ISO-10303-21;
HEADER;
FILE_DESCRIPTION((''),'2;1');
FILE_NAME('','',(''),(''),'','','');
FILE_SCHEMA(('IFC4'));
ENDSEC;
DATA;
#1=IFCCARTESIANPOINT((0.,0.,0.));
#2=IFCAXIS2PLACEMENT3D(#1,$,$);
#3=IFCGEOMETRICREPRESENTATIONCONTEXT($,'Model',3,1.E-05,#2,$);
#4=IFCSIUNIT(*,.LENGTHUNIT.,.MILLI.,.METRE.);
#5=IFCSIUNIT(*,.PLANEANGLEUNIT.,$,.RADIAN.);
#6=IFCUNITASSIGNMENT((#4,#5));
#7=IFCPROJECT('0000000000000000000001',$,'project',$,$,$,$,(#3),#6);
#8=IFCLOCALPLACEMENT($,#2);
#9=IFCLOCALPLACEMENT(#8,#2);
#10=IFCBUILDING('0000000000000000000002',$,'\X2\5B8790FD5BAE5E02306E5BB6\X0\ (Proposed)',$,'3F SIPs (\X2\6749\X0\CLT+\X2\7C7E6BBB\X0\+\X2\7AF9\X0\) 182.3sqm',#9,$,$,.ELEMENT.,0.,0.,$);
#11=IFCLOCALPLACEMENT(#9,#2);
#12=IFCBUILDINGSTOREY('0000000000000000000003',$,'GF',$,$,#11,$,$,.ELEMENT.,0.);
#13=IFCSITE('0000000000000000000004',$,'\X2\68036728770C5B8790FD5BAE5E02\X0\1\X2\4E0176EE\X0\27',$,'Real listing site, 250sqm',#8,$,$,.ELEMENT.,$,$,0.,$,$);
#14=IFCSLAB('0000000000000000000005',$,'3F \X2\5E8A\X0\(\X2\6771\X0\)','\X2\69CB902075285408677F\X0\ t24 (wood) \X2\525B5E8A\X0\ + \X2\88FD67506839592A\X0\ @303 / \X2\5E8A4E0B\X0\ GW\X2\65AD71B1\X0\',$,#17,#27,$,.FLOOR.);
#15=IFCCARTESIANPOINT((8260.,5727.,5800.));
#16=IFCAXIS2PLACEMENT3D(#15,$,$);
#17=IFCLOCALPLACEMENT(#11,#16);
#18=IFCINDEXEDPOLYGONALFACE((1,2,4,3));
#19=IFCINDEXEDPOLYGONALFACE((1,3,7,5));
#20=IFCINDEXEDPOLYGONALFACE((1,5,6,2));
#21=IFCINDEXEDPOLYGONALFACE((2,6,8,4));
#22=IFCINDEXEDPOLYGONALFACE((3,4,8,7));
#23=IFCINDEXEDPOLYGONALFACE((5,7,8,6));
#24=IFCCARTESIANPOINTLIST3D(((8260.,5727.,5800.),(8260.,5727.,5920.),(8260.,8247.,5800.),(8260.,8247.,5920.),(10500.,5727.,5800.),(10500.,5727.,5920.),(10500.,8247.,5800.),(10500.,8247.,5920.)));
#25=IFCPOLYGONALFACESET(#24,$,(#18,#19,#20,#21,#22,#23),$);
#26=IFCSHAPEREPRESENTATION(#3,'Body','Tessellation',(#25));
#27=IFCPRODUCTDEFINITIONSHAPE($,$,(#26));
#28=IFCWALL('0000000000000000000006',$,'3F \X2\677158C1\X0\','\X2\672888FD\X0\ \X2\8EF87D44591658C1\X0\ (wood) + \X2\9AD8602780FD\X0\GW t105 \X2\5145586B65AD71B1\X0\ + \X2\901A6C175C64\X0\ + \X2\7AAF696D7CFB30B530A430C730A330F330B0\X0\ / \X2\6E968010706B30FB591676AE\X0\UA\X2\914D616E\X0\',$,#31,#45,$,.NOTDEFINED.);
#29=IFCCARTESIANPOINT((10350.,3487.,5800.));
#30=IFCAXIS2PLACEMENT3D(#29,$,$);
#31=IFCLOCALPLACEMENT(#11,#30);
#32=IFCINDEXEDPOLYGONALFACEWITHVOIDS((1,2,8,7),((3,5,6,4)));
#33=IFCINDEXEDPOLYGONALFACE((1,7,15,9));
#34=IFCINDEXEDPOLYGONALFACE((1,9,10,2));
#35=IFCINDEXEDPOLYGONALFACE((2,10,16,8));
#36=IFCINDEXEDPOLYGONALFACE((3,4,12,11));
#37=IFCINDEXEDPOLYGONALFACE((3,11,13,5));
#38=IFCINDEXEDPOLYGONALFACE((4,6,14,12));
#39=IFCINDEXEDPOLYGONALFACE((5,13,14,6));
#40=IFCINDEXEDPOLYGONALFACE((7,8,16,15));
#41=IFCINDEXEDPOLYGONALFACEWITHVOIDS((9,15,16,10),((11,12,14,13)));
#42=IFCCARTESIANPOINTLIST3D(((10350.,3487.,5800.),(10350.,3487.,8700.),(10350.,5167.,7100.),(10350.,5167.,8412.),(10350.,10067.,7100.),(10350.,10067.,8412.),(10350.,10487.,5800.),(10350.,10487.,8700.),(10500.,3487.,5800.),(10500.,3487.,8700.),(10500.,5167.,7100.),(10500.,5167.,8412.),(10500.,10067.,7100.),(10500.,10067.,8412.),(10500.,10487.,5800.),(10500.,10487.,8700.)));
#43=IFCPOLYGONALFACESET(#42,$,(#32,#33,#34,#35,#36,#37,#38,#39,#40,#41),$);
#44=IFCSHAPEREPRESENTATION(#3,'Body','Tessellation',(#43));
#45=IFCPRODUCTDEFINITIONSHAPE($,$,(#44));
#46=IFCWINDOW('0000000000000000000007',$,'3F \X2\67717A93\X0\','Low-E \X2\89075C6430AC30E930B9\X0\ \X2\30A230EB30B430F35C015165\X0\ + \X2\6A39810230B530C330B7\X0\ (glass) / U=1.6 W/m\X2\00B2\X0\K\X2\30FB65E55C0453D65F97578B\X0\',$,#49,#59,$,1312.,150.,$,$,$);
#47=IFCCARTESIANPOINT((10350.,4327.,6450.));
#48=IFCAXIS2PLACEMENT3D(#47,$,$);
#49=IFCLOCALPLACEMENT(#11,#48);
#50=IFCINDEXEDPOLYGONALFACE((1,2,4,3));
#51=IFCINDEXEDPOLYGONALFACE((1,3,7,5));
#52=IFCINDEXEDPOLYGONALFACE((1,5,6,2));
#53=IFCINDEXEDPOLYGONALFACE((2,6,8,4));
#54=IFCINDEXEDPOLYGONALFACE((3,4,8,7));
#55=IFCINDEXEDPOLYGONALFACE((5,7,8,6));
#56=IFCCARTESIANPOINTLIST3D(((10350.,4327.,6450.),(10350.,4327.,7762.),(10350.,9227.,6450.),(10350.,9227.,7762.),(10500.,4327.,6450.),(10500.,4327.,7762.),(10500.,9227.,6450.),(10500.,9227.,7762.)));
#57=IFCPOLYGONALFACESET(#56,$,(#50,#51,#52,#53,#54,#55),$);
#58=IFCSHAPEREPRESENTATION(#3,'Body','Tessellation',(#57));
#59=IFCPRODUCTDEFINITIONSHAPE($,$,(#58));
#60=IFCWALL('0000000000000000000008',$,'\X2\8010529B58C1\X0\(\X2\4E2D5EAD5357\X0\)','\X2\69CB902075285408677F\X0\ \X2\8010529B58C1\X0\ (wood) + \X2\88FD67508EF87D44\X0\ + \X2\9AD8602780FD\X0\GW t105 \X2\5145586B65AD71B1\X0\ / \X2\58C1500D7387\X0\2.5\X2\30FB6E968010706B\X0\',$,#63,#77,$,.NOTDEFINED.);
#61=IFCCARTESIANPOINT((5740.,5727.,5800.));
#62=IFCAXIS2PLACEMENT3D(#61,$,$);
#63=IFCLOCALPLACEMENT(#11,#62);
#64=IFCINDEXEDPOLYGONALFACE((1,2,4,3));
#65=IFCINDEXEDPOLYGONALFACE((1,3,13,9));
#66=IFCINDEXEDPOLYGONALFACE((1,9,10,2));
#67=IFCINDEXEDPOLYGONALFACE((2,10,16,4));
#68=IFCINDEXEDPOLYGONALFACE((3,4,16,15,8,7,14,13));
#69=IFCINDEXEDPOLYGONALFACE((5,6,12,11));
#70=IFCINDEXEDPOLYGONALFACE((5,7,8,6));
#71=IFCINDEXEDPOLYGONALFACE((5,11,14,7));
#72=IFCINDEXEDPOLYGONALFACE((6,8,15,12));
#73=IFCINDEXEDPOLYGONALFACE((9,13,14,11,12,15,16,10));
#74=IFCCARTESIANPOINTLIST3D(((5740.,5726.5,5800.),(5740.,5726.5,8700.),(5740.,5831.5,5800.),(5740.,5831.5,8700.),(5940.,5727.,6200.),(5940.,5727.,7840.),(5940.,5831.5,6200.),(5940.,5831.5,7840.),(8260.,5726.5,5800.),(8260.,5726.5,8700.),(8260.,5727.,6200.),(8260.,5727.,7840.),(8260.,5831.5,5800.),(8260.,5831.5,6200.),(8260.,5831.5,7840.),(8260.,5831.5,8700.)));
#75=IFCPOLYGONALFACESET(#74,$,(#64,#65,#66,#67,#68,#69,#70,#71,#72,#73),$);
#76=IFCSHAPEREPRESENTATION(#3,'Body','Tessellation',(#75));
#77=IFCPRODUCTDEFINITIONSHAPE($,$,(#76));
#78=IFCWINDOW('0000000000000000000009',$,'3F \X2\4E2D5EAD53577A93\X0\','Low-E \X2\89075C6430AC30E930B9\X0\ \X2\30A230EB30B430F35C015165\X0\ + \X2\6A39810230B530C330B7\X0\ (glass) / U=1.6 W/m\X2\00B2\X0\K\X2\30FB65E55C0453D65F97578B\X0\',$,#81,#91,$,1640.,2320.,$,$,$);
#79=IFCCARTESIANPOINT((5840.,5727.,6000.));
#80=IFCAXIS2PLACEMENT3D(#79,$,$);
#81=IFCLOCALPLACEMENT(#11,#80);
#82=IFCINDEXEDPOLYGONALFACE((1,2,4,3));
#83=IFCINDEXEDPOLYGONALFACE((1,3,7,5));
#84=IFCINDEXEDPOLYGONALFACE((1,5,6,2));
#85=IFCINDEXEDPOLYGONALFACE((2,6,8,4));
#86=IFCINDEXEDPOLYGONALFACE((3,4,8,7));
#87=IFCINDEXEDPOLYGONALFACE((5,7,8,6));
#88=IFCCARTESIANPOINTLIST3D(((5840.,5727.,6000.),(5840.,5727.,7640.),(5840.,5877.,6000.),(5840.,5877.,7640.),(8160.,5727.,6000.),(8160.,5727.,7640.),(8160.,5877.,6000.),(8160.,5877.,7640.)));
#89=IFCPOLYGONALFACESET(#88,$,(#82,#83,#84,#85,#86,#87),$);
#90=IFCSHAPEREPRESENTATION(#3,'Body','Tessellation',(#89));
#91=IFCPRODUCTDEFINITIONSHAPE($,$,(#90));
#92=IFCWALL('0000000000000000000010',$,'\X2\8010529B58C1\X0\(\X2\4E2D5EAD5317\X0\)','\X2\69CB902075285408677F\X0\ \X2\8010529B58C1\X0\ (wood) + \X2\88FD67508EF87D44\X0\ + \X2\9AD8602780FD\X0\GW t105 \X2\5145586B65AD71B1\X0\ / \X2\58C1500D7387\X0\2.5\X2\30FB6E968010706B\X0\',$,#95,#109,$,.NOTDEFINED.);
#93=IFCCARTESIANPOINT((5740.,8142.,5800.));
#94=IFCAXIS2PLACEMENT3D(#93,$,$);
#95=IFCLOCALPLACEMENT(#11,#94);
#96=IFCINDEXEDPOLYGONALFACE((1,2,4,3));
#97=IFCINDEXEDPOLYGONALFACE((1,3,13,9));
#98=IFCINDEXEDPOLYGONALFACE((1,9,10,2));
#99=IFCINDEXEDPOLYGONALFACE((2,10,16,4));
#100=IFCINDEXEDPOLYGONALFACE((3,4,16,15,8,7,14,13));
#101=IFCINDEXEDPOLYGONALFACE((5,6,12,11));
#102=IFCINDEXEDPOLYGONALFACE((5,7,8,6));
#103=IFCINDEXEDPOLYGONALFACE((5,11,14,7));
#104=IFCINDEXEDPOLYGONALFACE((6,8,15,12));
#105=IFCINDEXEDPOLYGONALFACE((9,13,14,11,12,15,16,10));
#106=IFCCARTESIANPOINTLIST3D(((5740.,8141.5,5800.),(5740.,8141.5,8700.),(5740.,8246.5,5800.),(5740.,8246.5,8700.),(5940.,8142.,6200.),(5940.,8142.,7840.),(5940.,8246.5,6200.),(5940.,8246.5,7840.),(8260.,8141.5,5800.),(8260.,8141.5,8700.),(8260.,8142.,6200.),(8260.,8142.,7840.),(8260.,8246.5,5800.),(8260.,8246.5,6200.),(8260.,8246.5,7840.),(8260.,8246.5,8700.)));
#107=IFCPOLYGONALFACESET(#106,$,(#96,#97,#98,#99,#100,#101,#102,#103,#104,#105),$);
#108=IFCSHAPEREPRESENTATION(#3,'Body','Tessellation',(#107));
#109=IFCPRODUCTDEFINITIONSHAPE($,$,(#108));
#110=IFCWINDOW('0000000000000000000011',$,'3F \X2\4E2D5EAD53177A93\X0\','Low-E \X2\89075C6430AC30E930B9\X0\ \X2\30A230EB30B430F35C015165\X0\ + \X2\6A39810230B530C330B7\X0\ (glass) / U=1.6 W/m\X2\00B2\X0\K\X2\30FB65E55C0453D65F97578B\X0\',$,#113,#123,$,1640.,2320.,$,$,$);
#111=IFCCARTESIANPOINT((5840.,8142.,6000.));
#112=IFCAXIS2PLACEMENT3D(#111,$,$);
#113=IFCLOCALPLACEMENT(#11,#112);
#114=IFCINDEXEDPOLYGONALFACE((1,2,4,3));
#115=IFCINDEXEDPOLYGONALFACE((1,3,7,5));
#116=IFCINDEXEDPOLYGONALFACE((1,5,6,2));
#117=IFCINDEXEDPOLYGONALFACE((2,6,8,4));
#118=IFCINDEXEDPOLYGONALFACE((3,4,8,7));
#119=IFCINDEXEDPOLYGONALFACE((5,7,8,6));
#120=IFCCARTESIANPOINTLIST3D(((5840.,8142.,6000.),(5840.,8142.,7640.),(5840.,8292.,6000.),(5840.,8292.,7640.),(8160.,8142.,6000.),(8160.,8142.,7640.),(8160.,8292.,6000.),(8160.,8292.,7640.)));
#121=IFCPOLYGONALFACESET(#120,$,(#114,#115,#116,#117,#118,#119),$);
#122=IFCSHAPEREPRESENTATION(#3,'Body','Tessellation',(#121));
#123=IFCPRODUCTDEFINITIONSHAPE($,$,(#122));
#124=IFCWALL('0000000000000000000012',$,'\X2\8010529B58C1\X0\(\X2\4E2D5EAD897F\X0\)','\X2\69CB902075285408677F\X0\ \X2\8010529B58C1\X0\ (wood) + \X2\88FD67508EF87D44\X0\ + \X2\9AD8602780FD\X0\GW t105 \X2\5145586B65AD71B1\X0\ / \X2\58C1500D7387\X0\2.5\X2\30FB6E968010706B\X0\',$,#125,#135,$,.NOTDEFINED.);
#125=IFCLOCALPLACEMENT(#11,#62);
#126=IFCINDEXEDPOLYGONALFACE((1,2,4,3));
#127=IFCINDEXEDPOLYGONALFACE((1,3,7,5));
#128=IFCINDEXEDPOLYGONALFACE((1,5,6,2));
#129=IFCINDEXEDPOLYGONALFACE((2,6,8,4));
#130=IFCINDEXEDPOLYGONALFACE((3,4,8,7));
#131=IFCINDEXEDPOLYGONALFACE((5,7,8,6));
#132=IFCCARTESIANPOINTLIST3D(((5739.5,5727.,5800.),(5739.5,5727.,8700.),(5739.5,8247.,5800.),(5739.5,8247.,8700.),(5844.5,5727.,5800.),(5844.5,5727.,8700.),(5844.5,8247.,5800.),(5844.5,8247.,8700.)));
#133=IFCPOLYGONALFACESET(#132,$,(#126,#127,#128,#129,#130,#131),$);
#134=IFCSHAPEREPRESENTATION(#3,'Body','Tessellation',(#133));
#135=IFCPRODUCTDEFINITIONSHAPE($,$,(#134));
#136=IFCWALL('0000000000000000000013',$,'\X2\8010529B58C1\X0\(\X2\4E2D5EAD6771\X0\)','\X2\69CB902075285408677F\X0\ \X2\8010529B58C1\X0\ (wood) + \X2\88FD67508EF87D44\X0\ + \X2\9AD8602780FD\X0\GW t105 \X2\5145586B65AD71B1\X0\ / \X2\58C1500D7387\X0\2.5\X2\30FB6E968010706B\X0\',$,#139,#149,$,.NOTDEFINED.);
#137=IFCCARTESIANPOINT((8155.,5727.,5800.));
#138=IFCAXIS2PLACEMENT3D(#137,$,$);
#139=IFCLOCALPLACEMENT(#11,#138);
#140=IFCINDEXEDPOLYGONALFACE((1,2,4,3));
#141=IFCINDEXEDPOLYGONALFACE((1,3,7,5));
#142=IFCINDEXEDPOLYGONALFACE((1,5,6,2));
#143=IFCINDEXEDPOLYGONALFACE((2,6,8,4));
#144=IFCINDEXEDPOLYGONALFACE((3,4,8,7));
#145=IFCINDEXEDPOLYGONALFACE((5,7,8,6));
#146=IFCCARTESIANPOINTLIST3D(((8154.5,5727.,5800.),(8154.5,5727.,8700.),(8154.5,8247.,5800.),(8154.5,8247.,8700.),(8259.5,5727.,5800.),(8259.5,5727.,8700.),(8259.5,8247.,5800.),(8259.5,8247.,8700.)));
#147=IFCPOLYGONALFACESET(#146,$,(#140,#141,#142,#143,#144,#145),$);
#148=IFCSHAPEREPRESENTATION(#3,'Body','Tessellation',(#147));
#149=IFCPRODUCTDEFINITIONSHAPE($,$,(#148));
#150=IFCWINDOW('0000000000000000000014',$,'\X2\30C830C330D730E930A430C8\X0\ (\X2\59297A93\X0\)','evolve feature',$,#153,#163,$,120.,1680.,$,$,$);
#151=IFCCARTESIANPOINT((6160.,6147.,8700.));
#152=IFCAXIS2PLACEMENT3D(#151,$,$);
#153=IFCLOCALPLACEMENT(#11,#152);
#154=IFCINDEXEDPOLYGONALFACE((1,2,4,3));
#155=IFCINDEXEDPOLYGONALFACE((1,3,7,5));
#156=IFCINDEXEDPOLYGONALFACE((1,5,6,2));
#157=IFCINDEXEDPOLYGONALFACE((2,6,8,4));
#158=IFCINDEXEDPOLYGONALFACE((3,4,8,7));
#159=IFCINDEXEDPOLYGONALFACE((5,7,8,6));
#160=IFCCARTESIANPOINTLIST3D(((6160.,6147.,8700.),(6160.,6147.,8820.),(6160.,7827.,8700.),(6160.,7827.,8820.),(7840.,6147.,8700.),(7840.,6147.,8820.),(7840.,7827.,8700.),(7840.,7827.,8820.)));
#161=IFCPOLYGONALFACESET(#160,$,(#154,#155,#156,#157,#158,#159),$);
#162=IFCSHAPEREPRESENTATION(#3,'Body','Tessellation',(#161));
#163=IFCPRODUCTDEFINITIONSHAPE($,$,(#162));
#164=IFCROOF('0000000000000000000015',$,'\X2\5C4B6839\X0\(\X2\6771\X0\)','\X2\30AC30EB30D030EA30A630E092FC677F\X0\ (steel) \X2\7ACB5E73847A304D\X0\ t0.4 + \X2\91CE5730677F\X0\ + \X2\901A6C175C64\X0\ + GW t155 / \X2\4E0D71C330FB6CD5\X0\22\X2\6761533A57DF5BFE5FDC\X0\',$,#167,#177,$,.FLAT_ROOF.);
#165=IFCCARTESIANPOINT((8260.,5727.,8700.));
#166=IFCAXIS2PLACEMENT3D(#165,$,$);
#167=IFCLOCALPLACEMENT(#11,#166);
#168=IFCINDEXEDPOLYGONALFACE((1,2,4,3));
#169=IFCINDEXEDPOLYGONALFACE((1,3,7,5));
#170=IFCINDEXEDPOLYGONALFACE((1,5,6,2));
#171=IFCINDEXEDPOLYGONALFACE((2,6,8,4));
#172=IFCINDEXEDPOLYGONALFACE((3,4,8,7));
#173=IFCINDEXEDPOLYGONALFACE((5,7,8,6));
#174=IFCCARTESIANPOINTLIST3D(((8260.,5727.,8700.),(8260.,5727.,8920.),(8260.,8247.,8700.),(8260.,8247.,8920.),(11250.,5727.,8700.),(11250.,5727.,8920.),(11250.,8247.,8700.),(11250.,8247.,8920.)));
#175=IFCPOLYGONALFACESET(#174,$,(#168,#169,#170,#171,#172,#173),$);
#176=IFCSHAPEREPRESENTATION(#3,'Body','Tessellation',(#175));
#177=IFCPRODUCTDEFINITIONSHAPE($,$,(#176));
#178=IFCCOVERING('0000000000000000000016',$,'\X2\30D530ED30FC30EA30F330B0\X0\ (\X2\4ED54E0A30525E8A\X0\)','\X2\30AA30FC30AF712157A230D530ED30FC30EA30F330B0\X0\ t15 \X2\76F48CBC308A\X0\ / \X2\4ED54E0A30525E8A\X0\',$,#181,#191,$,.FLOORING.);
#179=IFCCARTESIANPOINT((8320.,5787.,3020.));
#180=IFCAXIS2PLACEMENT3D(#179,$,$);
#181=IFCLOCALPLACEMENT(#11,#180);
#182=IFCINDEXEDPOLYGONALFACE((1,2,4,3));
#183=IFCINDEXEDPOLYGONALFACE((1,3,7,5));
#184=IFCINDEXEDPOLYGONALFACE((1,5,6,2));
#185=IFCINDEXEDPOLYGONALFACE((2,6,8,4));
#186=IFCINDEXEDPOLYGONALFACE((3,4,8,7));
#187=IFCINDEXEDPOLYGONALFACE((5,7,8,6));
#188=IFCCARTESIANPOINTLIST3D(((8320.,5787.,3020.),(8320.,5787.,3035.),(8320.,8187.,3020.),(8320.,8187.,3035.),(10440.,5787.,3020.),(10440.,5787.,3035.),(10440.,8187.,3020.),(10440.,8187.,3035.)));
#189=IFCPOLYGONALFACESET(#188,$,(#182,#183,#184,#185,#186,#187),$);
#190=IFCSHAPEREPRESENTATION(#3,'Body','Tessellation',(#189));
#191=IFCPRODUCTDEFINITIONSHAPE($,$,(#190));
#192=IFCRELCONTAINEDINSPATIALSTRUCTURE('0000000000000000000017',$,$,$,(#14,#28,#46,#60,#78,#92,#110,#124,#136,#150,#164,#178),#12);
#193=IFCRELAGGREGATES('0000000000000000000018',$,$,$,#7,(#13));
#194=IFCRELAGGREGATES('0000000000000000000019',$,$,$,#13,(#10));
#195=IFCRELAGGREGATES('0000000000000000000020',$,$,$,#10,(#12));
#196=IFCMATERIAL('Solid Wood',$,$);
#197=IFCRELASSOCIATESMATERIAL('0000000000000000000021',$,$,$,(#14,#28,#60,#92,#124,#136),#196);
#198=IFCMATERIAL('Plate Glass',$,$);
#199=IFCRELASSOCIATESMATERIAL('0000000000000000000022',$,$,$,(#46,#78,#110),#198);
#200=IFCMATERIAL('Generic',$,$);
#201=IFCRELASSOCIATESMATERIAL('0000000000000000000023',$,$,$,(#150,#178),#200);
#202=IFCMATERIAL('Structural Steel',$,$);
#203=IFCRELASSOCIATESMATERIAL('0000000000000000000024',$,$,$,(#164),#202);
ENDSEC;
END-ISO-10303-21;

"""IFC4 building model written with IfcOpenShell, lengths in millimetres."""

from ifc_helpers import new_model, si_unit, frame, frame_2d, origin, place, context, project, spatial, rectangle, extrude, material, element, fill, save


model = new_model("IFC4")

# Units and contexts
model_context = context("Model", 3, precision=1e-05, world=origin())
ifc_project = project(units=[si_unit("LENGTHUNIT", "METRE", prefix="MILLI"), si_unit("PLANEANGLEUNIT", "RADIAN")], contexts=[model_context])

# Site, building, storey
site_placement = place(None, origin())
site = spatial("IfcSite", under=ifc_project, at=site_placement, Name="栃木県宇都宮市1丁目27", ObjectType="Real listing site, 250sqm", CompositionType="ELEMENT", RefElevation=0.0)
building_placement = place(site_placement, origin())
building = spatial("IfcBuilding", under=site, at=building_placement, Name="宇都宮市の家 (Proposed)", ObjectType="3F SIPs (杉CLT+籾殻+竹) 182.3sqm", CompositionType="ELEMENT", ElevationOfRefHeight=0.0, ElevationOfTerrain=0.0)
storey_placement = place(building_placement, origin())
storey = spatial("IfcBuildingStorey", under=building, at=storey_placement, Name="GF", CompositionType="ELEMENT", Elevation=0.0)

# Slab
ifc_material_1 = material(Name="Solid Wood")
slab_placement = place(storey_placement, frame((8260.0, 5727.0, 5800.0)))
element("IfcSlab", 1, at=slab_placement, inside=storey, material=ifc_material_1, Name="3F 床(東)", Description="構造用合板 t24 (wood) 剛床 + 製材根太 @303 / 床下 GW断熱", PredefinedType="FLOOR", context=model_context, shape_type="SweptSolid", body=[
    extrude(rectangle(XDim=2240.0, YDim=2520.0, at=frame_2d((1120.0, 1260.0))), frame((8260.0, 5727.0, 5800.0)), (0.0, 0.0, 1.0), 120.0),
])

# Walls, openings, windows
wall_1_placement = place(storey_placement, frame((10350.0, 3487.0, 5800.0)))
wall_1 = element("IfcWall", 2, at=wall_1_placement, inside=storey, material=ifc_material_1, Name="3F 東壁", Description="木製 軸組外壁 (wood) + 高性能GW t105 充填断熱 + 通気層 + 窯業系サイディング / 準耐火・外皮UA配慮", PredefinedType="NOTDEFINED", context=model_context, shape_type="SweptSolid", body=[
    extrude(rectangle(XDim=150.0, YDim=7000.0, at=frame_2d((75.0, 3500.0))), frame((10350.0, 3487.0, 5800.0)), (0.0, 0.0, 1.0), 2900.0),
])
opening_1_placement = place(storey_placement, frame((10350.0, 4327.0, 6450.0)))
opening_1 = element("IfcOpeningElement", 3, at=opening_1_placement, cuts=wall_1, PredefinedType="NOTDEFINED", context=model_context, shape_type="SweptSolid", body=[
    extrude(rectangle(XDim=150.0, YDim=4900.0, at=frame_2d((75.0, 2450.0))), frame((10350.0, 4327.0, 6450.0)), (0.0, 0.0, 1.0), 1312.0),
])
ifc_material_2 = material(Name="Plate Glass")
window_1_placement = place(storey_placement, frame((10350.0, 4327.0, 6450.0)))
window_1 = element("IfcWindow", 4, at=window_1_placement, inside=storey, material=ifc_material_2, Name="3F 東窓", Description="Low-E 複層ガラス アルゴン封入 + 樹脂サッシ (glass) / U=1.6 W/m²K・日射取得型", OverallHeight=1312.0, OverallWidth=150.0, context=model_context, shape_type="SweptSolid", body=[
    extrude(rectangle(XDim=150.0, YDim=4900.0, at=frame_2d((75.0, 2450.0))), frame((10350.0, 4327.0, 6450.0)), (0.0, 0.0, 1.0), 1312.0),
])
fill(opening_1, window_1)
wall_2_placement = place(storey_placement, frame((5740.0, 5727.0, 5800.0)))
wall_2 = element("IfcWall", 5, at=wall_2_placement, inside=storey, material=ifc_material_1, Name="耐力壁(中庭南)", Description="構造用合板 耐力壁 (wood) + 製材軸組 + 高性能GW t105 充填断熱 / 壁倍率2.5・準耐火", PredefinedType="NOTDEFINED", context=model_context, shape_type="SweptSolid", body=[
    extrude(rectangle(XDim=2520.0, YDim=105.0, at=frame_2d((1260.0, 52.0))), frame((5740.0, 5727.0, 5800.0)), (0.0, 0.0, 1.0), 2900.0),
])
opening_2_placement = place(storey_placement, frame((5840.0, 5727.0, 6000.0)))
opening_2 = element("IfcOpeningElement", 6, at=opening_2_placement, cuts=wall_2, PredefinedType="NOTDEFINED", context=model_context, shape_type="SweptSolid", body=[
    extrude(rectangle(XDim=2320.0, YDim=150.0, at=frame_2d((1160.0, 75.0))), frame((5840.0, 5727.0, 6000.0)), (0.0, 0.0, 1.0), 1640.0),
])
window_2_placement = place(storey_placement, frame((5840.0, 5727.0, 6000.0)))
window_2 = element("IfcWindow", 7, at=window_2_placement, inside=storey, material=ifc_material_2, Name="3F 中庭南窓", Description="Low-E 複層ガラス アルゴン封入 + 樹脂サッシ (glass) / U=1.6 W/m²K・日射取得型", OverallHeight=1640.0, OverallWidth=2320.0, context=model_context, shape_type="SweptSolid", body=[
    extrude(rectangle(XDim=2320.0, YDim=150.0, at=frame_2d((1160.0, 75.0))), frame((5840.0, 5727.0, 6000.0)), (0.0, 0.0, 1.0), 1640.0),
])
fill(opening_2, window_2)
wall_3_placement = place(storey_placement, frame((5740.0, 8142.0, 5800.0)))
wall_3 = element("IfcWall", 8, at=wall_3_placement, inside=storey, material=ifc_material_1, Name="耐力壁(中庭北)", Description="構造用合板 耐力壁 (wood) + 製材軸組 + 高性能GW t105 充填断熱 / 壁倍率2.5・準耐火", PredefinedType="NOTDEFINED", context=model_context, shape_type="SweptSolid", body=[
    extrude(rectangle(XDim=2520.0, YDim=105.0, at=frame_2d((1260.0, 52.0))), frame((5740.0, 8142.0, 5800.0)), (0.0, 0.0, 1.0), 2900.0),
])
opening_3_placement = place(storey_placement, frame((5840.0, 8142.0, 6000.0)))
opening_3 = element("IfcOpeningElement", 9, at=opening_3_placement, cuts=wall_3, PredefinedType="NOTDEFINED", context=model_context, shape_type="SweptSolid", body=[
    extrude(rectangle(XDim=2320.0, YDim=150.0, at=frame_2d((1160.0, 75.0))), frame((5840.0, 8142.0, 6000.0)), (0.0, 0.0, 1.0), 1640.0),
])
window_3_placement = place(storey_placement, frame((5840.0, 8142.0, 6000.0)))
window_3 = element("IfcWindow", 10, at=window_3_placement, inside=storey, material=ifc_material_2, Name="3F 中庭北窓", Description="Low-E 複層ガラス アルゴン封入 + 樹脂サッシ (glass) / U=1.6 W/m²K・日射取得型", OverallHeight=1640.0, OverallWidth=2320.0, context=model_context, shape_type="SweptSolid", body=[
    extrude(rectangle(XDim=2320.0, YDim=150.0, at=frame_2d((1160.0, 75.0))), frame((5840.0, 8142.0, 6000.0)), (0.0, 0.0, 1.0), 1640.0),
])
fill(opening_3, window_3)

# Walls
wall_4_placement = place(storey_placement, frame((5740.0, 5727.0, 5800.0)))
element("IfcWall", 11, at=wall_4_placement, inside=storey, material=ifc_material_1, Name="耐力壁(中庭西)", Description="構造用合板 耐力壁 (wood) + 製材軸組 + 高性能GW t105 充填断熱 / 壁倍率2.5・準耐火", PredefinedType="NOTDEFINED", context=model_context, shape_type="SweptSolid", body=[
    extrude(rectangle(XDim=105.0, YDim=2520.0, at=frame_2d((52.0, 1260.0))), frame((5740.0, 5727.0, 5800.0)), (0.0, 0.0, 1.0), 2900.0),
])
wall_5_placement = place(storey_placement, frame((8155.0, 5727.0, 5800.0)))
element("IfcWall", 12, at=wall_5_placement, inside=storey, material=ifc_material_1, Name="耐力壁(中庭東)", Description="構造用合板 耐力壁 (wood) + 製材軸組 + 高性能GW t105 充填断熱 / 壁倍率2.5・準耐火", PredefinedType="NOTDEFINED", context=model_context, shape_type="SweptSolid", body=[
    extrude(rectangle(XDim=105.0, YDim=2520.0, at=frame_2d((52.0, 1260.0))), frame((8155.0, 5727.0, 5800.0)), (0.0, 0.0, 1.0), 2900.0),
])

# Window
ifc_material_3 = material(Name="Generic")
window_4_placement = place(storey_placement, frame((6160.0, 6147.0, 8700.0)))
element("IfcWindow", 13, at=window_4_placement, inside=storey, material=ifc_material_3, Name="トップライト (天窓)", Description="evolve feature", OverallHeight=120.0, OverallWidth=1680.0, context=model_context, shape_type="SweptSolid", body=[
    extrude(rectangle(XDim=1680.0, YDim=1680.0, at=frame_2d((840.0, 840.0))), frame((6160.0, 6147.0, 8700.0)), (0.0, 0.0, 1.0), 120.0),
])

# Roof
ifc_material_4 = material(Name="Structural Steel")
for number, where, name in (
    (14, (8260.0, 5727.0, 8700.0), "屋根(東)"),
):
    element("IfcRoof", number, at=place(storey_placement, frame(where)), inside=storey, material=ifc_material_4, Name=name, Description="ガルバリウム鋼板 (steel) 立平葺き t0.4 + 野地板 + 通気層 + GW t155 / 不燃・法22条区域対応", PredefinedType="FLAT_ROOF", context=model_context, shape_type="SweptSolid", body=[
        extrude(rectangle(XDim=2990.0, YDim=2520.0, at=frame_2d((1495.0, 1260.0))), frame((8260.0, 5727.0, 8700.0)), (0.0, 0.0, 1.0), 220.0),
    ])

# Covering
covering_1_placement = place(storey_placement, frame((8320.0, 5787.0, 3020.0)))
element("IfcCovering", 15, at=covering_1_placement, inside=storey, material=ifc_material_3, Name="フローリング (仕上げ床)", Description="オーク無垢フローリング t15 直貼り / 仕上げ床", PredefinedType="FLOORING", context=model_context, shape_type="SweptSolid", body=[
    extrude(rectangle(XDim=2120.0, YDim=2400.0, at=frame_2d((1060.0, 1200.0))), frame((8320.0, 5787.0, 3020.0)), (0.0, 0.0, 1.0), 15.0),
])

save(model, "model.ifc")
